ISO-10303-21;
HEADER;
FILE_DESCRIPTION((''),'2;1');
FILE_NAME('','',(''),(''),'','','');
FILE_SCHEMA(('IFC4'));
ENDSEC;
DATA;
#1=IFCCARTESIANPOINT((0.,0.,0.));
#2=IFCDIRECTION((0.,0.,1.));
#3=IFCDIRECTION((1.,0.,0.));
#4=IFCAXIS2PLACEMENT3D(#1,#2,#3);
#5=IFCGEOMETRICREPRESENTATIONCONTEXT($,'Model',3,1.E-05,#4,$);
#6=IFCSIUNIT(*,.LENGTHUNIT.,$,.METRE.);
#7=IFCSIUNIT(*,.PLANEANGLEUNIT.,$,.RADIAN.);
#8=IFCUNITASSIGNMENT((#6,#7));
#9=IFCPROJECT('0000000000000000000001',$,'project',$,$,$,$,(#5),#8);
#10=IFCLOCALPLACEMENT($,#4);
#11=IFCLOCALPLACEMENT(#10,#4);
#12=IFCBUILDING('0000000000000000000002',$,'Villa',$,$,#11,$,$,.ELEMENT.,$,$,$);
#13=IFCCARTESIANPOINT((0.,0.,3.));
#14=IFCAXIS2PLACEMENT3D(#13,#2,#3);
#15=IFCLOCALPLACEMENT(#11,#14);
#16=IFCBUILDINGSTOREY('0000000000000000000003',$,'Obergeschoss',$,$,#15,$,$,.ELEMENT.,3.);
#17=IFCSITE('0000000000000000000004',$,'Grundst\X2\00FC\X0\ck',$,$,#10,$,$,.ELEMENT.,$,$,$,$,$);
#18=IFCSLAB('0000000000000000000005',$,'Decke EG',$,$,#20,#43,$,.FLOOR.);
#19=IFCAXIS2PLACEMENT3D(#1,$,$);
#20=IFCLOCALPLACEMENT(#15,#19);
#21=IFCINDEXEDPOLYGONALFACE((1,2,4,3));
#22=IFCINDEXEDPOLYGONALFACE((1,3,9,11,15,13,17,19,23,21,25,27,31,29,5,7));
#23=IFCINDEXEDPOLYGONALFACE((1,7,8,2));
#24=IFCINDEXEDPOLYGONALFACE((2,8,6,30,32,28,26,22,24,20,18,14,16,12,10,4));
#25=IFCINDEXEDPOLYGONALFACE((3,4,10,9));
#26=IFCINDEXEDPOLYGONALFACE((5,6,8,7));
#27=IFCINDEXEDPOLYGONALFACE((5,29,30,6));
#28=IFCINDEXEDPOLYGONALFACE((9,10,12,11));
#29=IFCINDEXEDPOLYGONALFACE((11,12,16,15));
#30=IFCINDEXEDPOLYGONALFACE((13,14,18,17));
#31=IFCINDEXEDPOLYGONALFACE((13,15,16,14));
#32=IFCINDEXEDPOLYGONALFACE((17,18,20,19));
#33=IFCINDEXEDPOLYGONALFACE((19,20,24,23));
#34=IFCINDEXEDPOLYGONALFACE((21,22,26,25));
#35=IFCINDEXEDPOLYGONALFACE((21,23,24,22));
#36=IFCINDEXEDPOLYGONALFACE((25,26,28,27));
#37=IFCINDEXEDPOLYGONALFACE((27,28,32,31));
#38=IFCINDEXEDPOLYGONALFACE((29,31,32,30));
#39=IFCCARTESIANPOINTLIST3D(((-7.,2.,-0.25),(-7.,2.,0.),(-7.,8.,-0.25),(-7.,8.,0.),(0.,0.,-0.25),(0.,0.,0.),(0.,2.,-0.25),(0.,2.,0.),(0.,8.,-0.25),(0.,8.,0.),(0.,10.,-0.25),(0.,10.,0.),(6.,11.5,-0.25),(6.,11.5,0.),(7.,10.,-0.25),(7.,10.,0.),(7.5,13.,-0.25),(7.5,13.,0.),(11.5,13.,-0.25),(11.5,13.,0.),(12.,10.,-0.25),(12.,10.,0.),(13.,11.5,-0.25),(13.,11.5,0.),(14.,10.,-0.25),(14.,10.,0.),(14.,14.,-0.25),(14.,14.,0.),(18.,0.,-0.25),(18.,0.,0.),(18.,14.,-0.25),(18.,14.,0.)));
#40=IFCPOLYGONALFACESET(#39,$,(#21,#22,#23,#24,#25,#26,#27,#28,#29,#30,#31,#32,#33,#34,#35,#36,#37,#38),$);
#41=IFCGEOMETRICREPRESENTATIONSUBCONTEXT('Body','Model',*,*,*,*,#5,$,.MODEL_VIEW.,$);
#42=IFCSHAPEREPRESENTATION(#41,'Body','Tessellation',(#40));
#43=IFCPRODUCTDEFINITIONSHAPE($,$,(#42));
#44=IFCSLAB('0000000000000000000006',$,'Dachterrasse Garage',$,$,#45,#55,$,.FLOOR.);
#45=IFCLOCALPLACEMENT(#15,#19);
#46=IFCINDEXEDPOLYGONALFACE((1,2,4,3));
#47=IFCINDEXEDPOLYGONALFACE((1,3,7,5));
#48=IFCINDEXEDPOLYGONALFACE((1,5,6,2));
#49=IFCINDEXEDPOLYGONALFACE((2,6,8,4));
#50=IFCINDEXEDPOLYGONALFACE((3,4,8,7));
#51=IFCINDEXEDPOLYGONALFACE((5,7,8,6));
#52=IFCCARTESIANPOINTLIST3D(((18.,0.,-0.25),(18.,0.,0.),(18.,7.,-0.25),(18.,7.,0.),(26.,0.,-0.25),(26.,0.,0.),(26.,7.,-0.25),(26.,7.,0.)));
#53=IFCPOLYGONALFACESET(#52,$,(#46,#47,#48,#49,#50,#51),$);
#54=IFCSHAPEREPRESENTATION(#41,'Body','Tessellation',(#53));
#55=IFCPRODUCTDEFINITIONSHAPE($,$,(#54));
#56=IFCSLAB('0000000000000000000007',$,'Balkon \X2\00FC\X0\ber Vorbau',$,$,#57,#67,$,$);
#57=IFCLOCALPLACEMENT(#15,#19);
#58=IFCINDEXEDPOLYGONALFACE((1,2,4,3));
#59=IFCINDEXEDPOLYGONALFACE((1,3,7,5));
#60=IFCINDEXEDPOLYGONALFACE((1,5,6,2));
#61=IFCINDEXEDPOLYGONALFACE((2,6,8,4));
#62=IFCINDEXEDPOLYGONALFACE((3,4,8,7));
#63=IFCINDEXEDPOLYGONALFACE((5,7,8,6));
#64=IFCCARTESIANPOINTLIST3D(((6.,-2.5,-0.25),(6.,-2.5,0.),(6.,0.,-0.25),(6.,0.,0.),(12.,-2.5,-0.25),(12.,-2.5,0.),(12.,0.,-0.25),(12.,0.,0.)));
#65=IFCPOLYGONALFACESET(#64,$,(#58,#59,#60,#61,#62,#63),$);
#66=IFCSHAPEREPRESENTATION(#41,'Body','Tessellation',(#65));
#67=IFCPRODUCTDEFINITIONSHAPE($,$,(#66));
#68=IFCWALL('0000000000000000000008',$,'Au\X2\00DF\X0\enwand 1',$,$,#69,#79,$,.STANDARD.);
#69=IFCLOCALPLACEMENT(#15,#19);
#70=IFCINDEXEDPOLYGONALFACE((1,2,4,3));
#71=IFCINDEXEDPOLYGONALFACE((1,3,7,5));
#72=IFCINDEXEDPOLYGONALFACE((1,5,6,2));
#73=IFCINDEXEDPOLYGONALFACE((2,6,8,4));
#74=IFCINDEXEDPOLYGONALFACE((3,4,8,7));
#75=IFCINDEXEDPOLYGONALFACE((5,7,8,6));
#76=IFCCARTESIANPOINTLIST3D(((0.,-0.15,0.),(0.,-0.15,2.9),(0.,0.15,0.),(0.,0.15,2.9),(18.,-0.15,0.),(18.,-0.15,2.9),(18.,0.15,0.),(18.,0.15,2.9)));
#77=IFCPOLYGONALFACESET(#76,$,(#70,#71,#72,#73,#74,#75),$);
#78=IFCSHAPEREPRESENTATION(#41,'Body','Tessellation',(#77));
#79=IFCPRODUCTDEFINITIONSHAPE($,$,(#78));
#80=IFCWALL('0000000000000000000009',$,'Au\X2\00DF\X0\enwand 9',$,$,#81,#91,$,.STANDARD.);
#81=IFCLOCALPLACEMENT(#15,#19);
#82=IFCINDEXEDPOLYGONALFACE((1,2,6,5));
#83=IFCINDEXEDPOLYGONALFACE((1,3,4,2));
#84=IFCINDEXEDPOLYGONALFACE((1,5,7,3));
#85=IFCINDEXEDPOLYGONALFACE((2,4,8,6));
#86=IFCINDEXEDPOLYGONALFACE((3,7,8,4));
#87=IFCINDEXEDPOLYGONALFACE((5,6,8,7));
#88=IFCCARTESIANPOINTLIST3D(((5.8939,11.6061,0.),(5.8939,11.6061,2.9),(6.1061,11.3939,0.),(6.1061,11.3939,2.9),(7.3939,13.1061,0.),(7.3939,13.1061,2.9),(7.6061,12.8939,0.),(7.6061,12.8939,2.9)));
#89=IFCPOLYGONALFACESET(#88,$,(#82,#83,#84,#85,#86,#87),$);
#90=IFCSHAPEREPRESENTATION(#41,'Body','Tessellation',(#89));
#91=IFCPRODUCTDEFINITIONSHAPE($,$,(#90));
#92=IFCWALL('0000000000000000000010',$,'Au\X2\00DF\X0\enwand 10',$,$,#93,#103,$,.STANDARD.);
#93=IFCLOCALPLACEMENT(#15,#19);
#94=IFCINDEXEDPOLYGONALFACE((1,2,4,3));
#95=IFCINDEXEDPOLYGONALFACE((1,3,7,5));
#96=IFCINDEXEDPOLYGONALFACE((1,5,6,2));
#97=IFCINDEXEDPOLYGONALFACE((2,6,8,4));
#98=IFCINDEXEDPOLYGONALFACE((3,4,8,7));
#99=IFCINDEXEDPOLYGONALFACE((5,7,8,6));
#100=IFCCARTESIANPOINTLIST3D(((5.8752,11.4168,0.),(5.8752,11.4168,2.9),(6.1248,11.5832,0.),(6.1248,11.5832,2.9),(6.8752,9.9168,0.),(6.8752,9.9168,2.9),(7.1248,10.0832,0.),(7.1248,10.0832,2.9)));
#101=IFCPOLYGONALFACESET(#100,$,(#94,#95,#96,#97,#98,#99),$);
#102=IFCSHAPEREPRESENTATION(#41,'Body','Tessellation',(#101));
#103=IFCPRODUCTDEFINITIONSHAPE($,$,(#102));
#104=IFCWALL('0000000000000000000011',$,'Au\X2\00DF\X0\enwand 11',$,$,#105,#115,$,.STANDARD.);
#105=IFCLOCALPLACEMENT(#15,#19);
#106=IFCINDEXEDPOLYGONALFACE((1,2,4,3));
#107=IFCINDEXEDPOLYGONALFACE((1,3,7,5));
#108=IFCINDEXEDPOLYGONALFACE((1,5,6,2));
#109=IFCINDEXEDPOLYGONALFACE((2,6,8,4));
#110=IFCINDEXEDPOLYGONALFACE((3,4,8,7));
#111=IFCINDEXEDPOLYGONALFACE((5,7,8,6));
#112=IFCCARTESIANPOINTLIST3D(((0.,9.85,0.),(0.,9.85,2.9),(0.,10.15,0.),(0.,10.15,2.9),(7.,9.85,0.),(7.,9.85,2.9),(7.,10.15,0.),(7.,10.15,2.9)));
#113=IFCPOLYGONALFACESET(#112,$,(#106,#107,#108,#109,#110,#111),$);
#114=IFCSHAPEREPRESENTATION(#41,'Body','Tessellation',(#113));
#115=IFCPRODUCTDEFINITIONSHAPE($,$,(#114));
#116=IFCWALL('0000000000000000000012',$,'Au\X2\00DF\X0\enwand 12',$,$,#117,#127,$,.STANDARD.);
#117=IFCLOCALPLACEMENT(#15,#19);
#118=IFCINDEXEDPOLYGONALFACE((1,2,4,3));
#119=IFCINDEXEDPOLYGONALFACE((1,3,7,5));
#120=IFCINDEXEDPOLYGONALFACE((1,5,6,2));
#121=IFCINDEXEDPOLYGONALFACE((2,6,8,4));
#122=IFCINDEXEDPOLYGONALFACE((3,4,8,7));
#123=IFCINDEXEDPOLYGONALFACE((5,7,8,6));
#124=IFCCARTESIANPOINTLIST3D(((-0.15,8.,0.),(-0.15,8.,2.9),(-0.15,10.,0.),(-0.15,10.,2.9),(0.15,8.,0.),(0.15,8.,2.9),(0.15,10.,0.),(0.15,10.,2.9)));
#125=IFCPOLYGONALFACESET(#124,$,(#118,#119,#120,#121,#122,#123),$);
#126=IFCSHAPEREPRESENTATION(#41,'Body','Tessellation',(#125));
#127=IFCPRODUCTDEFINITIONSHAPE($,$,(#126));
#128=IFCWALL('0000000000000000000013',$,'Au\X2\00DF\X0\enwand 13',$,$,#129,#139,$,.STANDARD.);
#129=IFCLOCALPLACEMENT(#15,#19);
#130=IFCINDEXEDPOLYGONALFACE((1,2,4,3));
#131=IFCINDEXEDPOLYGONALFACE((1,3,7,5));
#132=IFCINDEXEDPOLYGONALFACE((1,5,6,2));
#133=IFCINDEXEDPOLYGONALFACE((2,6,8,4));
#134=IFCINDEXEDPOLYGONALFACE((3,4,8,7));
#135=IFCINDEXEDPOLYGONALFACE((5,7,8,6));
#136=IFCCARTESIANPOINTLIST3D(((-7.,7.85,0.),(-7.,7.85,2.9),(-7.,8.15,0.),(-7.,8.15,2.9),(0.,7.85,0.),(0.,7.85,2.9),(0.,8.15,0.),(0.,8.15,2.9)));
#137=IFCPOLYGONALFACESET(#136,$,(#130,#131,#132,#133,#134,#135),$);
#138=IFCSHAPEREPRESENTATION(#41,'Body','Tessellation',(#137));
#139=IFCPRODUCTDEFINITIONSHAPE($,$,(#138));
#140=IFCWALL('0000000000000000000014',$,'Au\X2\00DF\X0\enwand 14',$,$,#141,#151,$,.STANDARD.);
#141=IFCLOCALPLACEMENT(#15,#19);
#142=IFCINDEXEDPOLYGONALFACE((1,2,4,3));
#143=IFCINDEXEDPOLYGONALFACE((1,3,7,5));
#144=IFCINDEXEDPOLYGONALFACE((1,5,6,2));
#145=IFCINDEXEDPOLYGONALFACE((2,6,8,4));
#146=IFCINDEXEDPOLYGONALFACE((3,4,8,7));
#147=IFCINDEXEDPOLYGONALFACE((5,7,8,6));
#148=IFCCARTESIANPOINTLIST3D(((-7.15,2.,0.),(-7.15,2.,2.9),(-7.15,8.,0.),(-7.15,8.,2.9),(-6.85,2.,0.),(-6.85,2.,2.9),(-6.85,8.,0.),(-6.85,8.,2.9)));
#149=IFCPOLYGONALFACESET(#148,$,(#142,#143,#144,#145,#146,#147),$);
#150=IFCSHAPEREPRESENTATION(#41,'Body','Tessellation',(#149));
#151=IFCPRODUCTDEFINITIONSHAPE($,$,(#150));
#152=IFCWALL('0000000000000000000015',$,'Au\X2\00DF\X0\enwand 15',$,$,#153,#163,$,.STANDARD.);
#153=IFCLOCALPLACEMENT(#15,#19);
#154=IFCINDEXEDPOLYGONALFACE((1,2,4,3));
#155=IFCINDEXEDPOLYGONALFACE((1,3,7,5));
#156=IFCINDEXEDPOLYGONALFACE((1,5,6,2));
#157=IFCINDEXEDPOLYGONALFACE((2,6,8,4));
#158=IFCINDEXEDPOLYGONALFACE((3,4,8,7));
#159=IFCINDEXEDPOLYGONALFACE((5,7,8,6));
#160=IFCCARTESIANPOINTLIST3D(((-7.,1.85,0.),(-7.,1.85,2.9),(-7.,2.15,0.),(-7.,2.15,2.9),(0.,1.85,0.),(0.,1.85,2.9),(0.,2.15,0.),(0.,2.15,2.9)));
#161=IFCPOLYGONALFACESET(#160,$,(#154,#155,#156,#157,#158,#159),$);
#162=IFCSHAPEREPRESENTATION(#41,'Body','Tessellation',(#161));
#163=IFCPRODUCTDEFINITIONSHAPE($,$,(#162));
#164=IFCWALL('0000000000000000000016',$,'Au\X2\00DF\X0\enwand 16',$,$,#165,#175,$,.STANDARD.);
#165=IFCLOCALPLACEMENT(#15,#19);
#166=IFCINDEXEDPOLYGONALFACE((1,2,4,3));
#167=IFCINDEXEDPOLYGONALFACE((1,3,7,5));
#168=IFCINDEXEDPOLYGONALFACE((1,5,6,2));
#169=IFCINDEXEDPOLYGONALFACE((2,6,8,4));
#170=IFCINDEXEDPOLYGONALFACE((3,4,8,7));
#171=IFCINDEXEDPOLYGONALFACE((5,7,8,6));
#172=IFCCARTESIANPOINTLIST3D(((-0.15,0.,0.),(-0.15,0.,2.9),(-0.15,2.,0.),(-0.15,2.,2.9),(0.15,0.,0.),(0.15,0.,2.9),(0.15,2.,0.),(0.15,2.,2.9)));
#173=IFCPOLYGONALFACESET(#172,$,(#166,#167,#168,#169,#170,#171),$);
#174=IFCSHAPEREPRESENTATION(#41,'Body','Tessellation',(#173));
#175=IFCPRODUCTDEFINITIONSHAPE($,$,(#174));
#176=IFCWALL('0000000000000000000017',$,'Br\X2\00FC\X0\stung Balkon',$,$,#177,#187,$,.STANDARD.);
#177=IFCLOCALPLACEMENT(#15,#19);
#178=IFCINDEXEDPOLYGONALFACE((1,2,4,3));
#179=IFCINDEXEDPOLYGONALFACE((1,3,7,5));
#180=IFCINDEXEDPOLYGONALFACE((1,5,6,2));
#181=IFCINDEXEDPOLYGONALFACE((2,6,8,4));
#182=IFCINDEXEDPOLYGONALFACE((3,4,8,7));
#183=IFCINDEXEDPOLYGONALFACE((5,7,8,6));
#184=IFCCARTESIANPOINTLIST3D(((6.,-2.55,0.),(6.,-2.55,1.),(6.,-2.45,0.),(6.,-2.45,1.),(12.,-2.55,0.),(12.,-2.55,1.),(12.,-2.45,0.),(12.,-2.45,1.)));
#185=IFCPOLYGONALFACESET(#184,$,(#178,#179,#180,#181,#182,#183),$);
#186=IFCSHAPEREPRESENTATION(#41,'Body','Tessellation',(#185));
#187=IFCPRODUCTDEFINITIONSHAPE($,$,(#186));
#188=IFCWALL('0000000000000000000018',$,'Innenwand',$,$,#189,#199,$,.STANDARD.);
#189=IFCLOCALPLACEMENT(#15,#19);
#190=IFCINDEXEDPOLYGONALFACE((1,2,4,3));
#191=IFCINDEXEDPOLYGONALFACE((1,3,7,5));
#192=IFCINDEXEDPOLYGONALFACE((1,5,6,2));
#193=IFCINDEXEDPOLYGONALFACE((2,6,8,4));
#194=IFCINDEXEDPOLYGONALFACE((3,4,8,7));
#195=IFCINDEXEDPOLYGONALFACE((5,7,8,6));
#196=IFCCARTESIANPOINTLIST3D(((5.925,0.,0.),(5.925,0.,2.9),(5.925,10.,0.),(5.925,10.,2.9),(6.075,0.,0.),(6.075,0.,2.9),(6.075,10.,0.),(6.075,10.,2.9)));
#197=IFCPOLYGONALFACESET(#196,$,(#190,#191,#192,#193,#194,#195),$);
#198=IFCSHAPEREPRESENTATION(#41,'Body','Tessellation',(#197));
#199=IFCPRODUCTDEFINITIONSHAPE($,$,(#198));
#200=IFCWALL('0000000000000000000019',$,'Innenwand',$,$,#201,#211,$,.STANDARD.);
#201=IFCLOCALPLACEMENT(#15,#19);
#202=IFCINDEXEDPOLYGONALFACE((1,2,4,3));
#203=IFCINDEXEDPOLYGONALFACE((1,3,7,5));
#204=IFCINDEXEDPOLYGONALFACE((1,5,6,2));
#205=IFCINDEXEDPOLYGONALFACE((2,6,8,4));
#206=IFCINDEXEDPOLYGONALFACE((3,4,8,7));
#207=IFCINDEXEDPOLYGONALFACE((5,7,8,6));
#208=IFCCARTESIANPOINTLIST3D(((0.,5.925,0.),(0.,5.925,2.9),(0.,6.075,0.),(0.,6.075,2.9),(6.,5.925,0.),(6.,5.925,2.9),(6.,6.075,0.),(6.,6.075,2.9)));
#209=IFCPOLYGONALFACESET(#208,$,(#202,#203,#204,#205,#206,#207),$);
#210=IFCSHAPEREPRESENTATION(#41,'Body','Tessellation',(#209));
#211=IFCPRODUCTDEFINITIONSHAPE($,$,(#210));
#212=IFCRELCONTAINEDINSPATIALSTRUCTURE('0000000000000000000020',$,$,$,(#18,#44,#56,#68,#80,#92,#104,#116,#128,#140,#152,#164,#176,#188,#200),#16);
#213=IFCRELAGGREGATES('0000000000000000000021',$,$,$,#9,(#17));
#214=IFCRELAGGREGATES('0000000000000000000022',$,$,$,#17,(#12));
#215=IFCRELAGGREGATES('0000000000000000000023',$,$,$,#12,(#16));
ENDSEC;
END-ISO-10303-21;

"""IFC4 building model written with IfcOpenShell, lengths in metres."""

from ifc_helpers import new_model, si_unit, frame, frame_2d, origin_with_axes, place, context, subcontext, project, spatial, polyline, rectangle, outline, extrude, element, save


model = new_model("IFC4")

# Units and contexts
model_context = context("Model", 3, precision=1e-05, world=origin_with_axes())
body_context = subcontext(model_context, "Body", "Model", "MODEL_VIEW")
ifc_project = project(units=[si_unit("LENGTHUNIT", "METRE"), si_unit("PLANEANGLEUNIT", "RADIAN")], contexts=[model_context])

# Site, building, storey
site_placement = place(None, origin_with_axes())
site = spatial("IfcSite", under=ifc_project, at=site_placement, Name="Grundstück", CompositionType="ELEMENT")
building_placement = place(site_placement, origin_with_axes())
building = spatial("IfcBuilding", under=site, at=building_placement, Name="Villa", CompositionType="ELEMENT")
storey_placement = place(building_placement, frame((0.0, 0.0, 3.0), z_axis=(0.0, 0.0, 1.0), x_axis=(1.0, 0.0, 0.0)))
storey = spatial("IfcBuildingStorey", under=building, at=storey_placement, Name="Obergeschoss", CompositionType="ELEMENT", Elevation=3.0)

# Slabs
slab_1_placement = place(storey_placement, frame((0.0, 0.0, -0.25), z_axis=(0.0, 0.0, 1.0), x_axis=(1.0, 0.0, 0.0)))
element("IfcSlab", 1, at=slab_1_placement, inside=storey, Name="Decke EG", PredefinedType="FLOOR", context=body_context, shape_type="SweptSolid", body=[
    extrude(outline(polyline([(0.0, 0.0), (18.0, 0.0), (18.0, 14.0), (14.0, 14.0), (14.0, 10.0), (12.0, 10.0), (13.0, 11.5), (11.5, 13.0), (7.5, 13.0), (6.0, 11.5), (7.0, 10.0), (0.0, 10.0), (0.0, 8.0), (-7.0, 8.0), (-7.0, 2.0), (0.0, 2.0), (0.0, 0.0)])), origin_with_axes(), (0.0, 0.0, 1.0), 0.25),
])
slab_2_placement = place(storey_placement, frame((0.0, 0.0, -0.25), z_axis=(0.0, 0.0, 1.0), x_axis=(1.0, 0.0, 0.0)))
element("IfcSlab", 2, at=slab_2_placement, inside=storey, Name="Dachterrasse Garage", PredefinedType="FLOOR", context=body_context, shape_type="SweptSolid", body=[
    extrude(outline(polyline([(18.0, 0.0), (26.0, 0.0), (26.0, 7.0), (18.0, 7.0), (18.0, 0.0)])), origin_with_axes(), (0.0, 0.0, 1.0), 0.25),
])
slab_3_placement = place(storey_placement, frame((0.0, 0.0, -0.25), z_axis=(0.0, 0.0, 1.0), x_axis=(1.0, 0.0, 0.0)))
element("IfcSlab", 3, at=slab_3_placement, inside=storey, Name="Balkon über Vorbau", context=body_context, shape_type="SweptSolid", body=[
    extrude(outline(polyline([(6.0, -2.5), (12.0, -2.5), (12.0, 0.0), (6.0, 0.0), (6.0, -2.5)])), origin_with_axes(), (0.0, 0.0, 1.0), 0.25),
])

# Walls
wall_1_placement = place(storey_placement, origin_with_axes())
element("IfcWall", 4, at=wall_1_placement, inside=storey, Name="Außenwand 1", PredefinedType="STANDARD", context=body_context, shape_type="SweptSolid", body=[
    extrude(rectangle(XDim=18.0, YDim=0.3, at=frame_2d((9.0, 0.0))), origin_with_axes(), (0.0, 0.0, 1.0), 2.9),
])
wall_2_placement = place(storey_placement, frame((7.5, 13.0, 0.0), z_axis=(0.0, 0.0, 1.0), x_axis=(-0.707107, -0.707107, 0.0)))
element("IfcWall", 5, at=wall_2_placement, inside=storey, Name="Außenwand 9", PredefinedType="STANDARD", context=body_context, shape_type="SweptSolid", body=[
    extrude(rectangle(XDim=2.1213, YDim=0.3, at=frame_2d((1.0607, 0.0))), origin_with_axes(), (0.0, 0.0, 1.0), 2.9),
])
wall_3_placement = place(storey_placement, frame((6.0, 11.5, 0.0), z_axis=(0.0, 0.0, 1.0), x_axis=(0.5547, -0.83205, 0.0)))
element("IfcWall", 6, at=wall_3_placement, inside=storey, Name="Außenwand 10", PredefinedType="STANDARD", context=body_context, shape_type="SweptSolid", body=[
    extrude(rectangle(XDim=1.8028, YDim=0.3, at=frame_2d((0.9014, 0.0))), origin_with_axes(), (0.0, 0.0, 1.0), 2.9),
])
wall_4_placement = place(storey_placement, frame((7.0, 10.0, 0.0), z_axis=(0.0, 0.0, 1.0), x_axis=(-1.0, 0.0, 0.0)))
element("IfcWall", 7, at=wall_4_placement, inside=storey, Name="Außenwand 11", PredefinedType="STANDARD", context=body_context, shape_type="SweptSolid", body=[
    extrude(rectangle(XDim=7.0, YDim=0.3, at=frame_2d((3.5, 0.0))), origin_with_axes(), (0.0, 0.0, 1.0), 2.9),
])
wall_5_placement = place(storey_placement, frame((0.0, 10.0, 0.0), z_axis=(0.0, 0.0, 1.0), x_axis=(0.0, -1.0, 0.0)))
element("IfcWall", 8, at=wall_5_placement, inside=storey, Name="Außenwand 12", PredefinedType="STANDARD", context=body_context, shape_type="SweptSolid", body=[
    extrude(rectangle(XDim=2.0, YDim=0.3, at=frame_2d((1.0, 0.0))), origin_with_axes(), (0.0, 0.0, 1.0), 2.9),
])
wall_6_placement = place(storey_placement, frame((0.0, 8.0, 0.0), z_axis=(0.0, 0.0, 1.0), x_axis=(-1.0, 0.0, 0.0)))
element("IfcWall", 9, at=wall_6_placement, inside=storey, Name="Außenwand 13", PredefinedType="STANDARD", context=body_context, shape_type="SweptSolid", body=[
    extrude(rectangle(XDim=7.0, YDim=0.3, at=frame_2d((3.5, 0.0))), origin_with_axes(), (0.0, 0.0, 1.0), 2.9),
])
wall_7_placement = place(storey_placement, frame((-7.0, 8.0, 0.0), z_axis=(0.0, 0.0, 1.0), x_axis=(0.0, -1.0, 0.0)))
element("IfcWall", 10, at=wall_7_placement, inside=storey, Name="Außenwand 14", PredefinedType="STANDARD", context=body_context, shape_type="SweptSolid", body=[
    extrude(rectangle(XDim=6.0, YDim=0.3, at=frame_2d((3.0, 0.0))), origin_with_axes(), (0.0, 0.0, 1.0), 2.9),
])
wall_8_placement = place(storey_placement, frame((-7.0, 2.0, 0.0), z_axis=(0.0, 0.0, 1.0), x_axis=(1.0, 0.0, 0.0)))
element("IfcWall", 11, at=wall_8_placement, inside=storey, Name="Außenwand 15", PredefinedType="STANDARD", context=body_context, shape_type="SweptSolid", body=[
    extrude(rectangle(XDim=7.0, YDim=0.3, at=frame_2d((3.5, 0.0))), origin_with_axes(), (0.0, 0.0, 1.0), 2.9),
])
wall_9_placement = place(storey_placement, frame((0.0, 2.0, 0.0), z_axis=(0.0, 0.0, 1.0), x_axis=(0.0, -1.0, 0.0)))
element("IfcWall", 12, at=wall_9_placement, inside=storey, Name="Außenwand 16", PredefinedType="STANDARD", context=body_context, shape_type="SweptSolid", body=[
    extrude(rectangle(XDim=2.0, YDim=0.3, at=frame_2d((1.0, 0.0))), origin_with_axes(), (0.0, 0.0, 1.0), 2.9),
])
wall_10_placement = place(storey_placement, frame((6.0, -2.5, 0.0), z_axis=(0.0, 0.0, 1.0), x_axis=(1.0, 0.0, 0.0)))
element("IfcWall", 13, at=wall_10_placement, inside=storey, Name="Brüstung Balkon", PredefinedType="STANDARD", context=body_context, shape_type="SweptSolid", body=[
    extrude(rectangle(XDim=6.0, YDim=0.1, at=frame_2d((3.0, 0.0))), origin_with_axes(), (0.0, 0.0, 1.0), 1.0),
])
wall_11_placement = place(storey_placement, frame((6.0, 0.0, 0.0), z_axis=(0.0, 0.0, 1.0), x_axis=(0.0, 1.0, 0.0)))
element("IfcWall", 14, at=wall_11_placement, inside=storey, Name="Innenwand", PredefinedType="STANDARD", context=body_context, shape_type="SweptSolid", body=[
    extrude(rectangle(XDim=10.0, YDim=0.15, at=frame_2d((5.0, 0.0))), origin_with_axes(), (0.0, 0.0, 1.0), 2.9),
])
wall_12_placement = place(storey_placement, frame((0.0, 6.0, 0.0), z_axis=(0.0, 0.0, 1.0), x_axis=(1.0, 0.0, 0.0)))
element("IfcWall", 15, at=wall_12_placement, inside=storey, Name="Innenwand", PredefinedType="STANDARD", context=body_context, shape_type="SweptSolid", body=[
    extrude(rectangle(XDim=6.0, YDim=0.15, at=frame_2d((3.0, 0.0))), origin_with_axes(), (0.0, 0.0, 1.0), 2.9),
])

save(model, "model.ifc")
